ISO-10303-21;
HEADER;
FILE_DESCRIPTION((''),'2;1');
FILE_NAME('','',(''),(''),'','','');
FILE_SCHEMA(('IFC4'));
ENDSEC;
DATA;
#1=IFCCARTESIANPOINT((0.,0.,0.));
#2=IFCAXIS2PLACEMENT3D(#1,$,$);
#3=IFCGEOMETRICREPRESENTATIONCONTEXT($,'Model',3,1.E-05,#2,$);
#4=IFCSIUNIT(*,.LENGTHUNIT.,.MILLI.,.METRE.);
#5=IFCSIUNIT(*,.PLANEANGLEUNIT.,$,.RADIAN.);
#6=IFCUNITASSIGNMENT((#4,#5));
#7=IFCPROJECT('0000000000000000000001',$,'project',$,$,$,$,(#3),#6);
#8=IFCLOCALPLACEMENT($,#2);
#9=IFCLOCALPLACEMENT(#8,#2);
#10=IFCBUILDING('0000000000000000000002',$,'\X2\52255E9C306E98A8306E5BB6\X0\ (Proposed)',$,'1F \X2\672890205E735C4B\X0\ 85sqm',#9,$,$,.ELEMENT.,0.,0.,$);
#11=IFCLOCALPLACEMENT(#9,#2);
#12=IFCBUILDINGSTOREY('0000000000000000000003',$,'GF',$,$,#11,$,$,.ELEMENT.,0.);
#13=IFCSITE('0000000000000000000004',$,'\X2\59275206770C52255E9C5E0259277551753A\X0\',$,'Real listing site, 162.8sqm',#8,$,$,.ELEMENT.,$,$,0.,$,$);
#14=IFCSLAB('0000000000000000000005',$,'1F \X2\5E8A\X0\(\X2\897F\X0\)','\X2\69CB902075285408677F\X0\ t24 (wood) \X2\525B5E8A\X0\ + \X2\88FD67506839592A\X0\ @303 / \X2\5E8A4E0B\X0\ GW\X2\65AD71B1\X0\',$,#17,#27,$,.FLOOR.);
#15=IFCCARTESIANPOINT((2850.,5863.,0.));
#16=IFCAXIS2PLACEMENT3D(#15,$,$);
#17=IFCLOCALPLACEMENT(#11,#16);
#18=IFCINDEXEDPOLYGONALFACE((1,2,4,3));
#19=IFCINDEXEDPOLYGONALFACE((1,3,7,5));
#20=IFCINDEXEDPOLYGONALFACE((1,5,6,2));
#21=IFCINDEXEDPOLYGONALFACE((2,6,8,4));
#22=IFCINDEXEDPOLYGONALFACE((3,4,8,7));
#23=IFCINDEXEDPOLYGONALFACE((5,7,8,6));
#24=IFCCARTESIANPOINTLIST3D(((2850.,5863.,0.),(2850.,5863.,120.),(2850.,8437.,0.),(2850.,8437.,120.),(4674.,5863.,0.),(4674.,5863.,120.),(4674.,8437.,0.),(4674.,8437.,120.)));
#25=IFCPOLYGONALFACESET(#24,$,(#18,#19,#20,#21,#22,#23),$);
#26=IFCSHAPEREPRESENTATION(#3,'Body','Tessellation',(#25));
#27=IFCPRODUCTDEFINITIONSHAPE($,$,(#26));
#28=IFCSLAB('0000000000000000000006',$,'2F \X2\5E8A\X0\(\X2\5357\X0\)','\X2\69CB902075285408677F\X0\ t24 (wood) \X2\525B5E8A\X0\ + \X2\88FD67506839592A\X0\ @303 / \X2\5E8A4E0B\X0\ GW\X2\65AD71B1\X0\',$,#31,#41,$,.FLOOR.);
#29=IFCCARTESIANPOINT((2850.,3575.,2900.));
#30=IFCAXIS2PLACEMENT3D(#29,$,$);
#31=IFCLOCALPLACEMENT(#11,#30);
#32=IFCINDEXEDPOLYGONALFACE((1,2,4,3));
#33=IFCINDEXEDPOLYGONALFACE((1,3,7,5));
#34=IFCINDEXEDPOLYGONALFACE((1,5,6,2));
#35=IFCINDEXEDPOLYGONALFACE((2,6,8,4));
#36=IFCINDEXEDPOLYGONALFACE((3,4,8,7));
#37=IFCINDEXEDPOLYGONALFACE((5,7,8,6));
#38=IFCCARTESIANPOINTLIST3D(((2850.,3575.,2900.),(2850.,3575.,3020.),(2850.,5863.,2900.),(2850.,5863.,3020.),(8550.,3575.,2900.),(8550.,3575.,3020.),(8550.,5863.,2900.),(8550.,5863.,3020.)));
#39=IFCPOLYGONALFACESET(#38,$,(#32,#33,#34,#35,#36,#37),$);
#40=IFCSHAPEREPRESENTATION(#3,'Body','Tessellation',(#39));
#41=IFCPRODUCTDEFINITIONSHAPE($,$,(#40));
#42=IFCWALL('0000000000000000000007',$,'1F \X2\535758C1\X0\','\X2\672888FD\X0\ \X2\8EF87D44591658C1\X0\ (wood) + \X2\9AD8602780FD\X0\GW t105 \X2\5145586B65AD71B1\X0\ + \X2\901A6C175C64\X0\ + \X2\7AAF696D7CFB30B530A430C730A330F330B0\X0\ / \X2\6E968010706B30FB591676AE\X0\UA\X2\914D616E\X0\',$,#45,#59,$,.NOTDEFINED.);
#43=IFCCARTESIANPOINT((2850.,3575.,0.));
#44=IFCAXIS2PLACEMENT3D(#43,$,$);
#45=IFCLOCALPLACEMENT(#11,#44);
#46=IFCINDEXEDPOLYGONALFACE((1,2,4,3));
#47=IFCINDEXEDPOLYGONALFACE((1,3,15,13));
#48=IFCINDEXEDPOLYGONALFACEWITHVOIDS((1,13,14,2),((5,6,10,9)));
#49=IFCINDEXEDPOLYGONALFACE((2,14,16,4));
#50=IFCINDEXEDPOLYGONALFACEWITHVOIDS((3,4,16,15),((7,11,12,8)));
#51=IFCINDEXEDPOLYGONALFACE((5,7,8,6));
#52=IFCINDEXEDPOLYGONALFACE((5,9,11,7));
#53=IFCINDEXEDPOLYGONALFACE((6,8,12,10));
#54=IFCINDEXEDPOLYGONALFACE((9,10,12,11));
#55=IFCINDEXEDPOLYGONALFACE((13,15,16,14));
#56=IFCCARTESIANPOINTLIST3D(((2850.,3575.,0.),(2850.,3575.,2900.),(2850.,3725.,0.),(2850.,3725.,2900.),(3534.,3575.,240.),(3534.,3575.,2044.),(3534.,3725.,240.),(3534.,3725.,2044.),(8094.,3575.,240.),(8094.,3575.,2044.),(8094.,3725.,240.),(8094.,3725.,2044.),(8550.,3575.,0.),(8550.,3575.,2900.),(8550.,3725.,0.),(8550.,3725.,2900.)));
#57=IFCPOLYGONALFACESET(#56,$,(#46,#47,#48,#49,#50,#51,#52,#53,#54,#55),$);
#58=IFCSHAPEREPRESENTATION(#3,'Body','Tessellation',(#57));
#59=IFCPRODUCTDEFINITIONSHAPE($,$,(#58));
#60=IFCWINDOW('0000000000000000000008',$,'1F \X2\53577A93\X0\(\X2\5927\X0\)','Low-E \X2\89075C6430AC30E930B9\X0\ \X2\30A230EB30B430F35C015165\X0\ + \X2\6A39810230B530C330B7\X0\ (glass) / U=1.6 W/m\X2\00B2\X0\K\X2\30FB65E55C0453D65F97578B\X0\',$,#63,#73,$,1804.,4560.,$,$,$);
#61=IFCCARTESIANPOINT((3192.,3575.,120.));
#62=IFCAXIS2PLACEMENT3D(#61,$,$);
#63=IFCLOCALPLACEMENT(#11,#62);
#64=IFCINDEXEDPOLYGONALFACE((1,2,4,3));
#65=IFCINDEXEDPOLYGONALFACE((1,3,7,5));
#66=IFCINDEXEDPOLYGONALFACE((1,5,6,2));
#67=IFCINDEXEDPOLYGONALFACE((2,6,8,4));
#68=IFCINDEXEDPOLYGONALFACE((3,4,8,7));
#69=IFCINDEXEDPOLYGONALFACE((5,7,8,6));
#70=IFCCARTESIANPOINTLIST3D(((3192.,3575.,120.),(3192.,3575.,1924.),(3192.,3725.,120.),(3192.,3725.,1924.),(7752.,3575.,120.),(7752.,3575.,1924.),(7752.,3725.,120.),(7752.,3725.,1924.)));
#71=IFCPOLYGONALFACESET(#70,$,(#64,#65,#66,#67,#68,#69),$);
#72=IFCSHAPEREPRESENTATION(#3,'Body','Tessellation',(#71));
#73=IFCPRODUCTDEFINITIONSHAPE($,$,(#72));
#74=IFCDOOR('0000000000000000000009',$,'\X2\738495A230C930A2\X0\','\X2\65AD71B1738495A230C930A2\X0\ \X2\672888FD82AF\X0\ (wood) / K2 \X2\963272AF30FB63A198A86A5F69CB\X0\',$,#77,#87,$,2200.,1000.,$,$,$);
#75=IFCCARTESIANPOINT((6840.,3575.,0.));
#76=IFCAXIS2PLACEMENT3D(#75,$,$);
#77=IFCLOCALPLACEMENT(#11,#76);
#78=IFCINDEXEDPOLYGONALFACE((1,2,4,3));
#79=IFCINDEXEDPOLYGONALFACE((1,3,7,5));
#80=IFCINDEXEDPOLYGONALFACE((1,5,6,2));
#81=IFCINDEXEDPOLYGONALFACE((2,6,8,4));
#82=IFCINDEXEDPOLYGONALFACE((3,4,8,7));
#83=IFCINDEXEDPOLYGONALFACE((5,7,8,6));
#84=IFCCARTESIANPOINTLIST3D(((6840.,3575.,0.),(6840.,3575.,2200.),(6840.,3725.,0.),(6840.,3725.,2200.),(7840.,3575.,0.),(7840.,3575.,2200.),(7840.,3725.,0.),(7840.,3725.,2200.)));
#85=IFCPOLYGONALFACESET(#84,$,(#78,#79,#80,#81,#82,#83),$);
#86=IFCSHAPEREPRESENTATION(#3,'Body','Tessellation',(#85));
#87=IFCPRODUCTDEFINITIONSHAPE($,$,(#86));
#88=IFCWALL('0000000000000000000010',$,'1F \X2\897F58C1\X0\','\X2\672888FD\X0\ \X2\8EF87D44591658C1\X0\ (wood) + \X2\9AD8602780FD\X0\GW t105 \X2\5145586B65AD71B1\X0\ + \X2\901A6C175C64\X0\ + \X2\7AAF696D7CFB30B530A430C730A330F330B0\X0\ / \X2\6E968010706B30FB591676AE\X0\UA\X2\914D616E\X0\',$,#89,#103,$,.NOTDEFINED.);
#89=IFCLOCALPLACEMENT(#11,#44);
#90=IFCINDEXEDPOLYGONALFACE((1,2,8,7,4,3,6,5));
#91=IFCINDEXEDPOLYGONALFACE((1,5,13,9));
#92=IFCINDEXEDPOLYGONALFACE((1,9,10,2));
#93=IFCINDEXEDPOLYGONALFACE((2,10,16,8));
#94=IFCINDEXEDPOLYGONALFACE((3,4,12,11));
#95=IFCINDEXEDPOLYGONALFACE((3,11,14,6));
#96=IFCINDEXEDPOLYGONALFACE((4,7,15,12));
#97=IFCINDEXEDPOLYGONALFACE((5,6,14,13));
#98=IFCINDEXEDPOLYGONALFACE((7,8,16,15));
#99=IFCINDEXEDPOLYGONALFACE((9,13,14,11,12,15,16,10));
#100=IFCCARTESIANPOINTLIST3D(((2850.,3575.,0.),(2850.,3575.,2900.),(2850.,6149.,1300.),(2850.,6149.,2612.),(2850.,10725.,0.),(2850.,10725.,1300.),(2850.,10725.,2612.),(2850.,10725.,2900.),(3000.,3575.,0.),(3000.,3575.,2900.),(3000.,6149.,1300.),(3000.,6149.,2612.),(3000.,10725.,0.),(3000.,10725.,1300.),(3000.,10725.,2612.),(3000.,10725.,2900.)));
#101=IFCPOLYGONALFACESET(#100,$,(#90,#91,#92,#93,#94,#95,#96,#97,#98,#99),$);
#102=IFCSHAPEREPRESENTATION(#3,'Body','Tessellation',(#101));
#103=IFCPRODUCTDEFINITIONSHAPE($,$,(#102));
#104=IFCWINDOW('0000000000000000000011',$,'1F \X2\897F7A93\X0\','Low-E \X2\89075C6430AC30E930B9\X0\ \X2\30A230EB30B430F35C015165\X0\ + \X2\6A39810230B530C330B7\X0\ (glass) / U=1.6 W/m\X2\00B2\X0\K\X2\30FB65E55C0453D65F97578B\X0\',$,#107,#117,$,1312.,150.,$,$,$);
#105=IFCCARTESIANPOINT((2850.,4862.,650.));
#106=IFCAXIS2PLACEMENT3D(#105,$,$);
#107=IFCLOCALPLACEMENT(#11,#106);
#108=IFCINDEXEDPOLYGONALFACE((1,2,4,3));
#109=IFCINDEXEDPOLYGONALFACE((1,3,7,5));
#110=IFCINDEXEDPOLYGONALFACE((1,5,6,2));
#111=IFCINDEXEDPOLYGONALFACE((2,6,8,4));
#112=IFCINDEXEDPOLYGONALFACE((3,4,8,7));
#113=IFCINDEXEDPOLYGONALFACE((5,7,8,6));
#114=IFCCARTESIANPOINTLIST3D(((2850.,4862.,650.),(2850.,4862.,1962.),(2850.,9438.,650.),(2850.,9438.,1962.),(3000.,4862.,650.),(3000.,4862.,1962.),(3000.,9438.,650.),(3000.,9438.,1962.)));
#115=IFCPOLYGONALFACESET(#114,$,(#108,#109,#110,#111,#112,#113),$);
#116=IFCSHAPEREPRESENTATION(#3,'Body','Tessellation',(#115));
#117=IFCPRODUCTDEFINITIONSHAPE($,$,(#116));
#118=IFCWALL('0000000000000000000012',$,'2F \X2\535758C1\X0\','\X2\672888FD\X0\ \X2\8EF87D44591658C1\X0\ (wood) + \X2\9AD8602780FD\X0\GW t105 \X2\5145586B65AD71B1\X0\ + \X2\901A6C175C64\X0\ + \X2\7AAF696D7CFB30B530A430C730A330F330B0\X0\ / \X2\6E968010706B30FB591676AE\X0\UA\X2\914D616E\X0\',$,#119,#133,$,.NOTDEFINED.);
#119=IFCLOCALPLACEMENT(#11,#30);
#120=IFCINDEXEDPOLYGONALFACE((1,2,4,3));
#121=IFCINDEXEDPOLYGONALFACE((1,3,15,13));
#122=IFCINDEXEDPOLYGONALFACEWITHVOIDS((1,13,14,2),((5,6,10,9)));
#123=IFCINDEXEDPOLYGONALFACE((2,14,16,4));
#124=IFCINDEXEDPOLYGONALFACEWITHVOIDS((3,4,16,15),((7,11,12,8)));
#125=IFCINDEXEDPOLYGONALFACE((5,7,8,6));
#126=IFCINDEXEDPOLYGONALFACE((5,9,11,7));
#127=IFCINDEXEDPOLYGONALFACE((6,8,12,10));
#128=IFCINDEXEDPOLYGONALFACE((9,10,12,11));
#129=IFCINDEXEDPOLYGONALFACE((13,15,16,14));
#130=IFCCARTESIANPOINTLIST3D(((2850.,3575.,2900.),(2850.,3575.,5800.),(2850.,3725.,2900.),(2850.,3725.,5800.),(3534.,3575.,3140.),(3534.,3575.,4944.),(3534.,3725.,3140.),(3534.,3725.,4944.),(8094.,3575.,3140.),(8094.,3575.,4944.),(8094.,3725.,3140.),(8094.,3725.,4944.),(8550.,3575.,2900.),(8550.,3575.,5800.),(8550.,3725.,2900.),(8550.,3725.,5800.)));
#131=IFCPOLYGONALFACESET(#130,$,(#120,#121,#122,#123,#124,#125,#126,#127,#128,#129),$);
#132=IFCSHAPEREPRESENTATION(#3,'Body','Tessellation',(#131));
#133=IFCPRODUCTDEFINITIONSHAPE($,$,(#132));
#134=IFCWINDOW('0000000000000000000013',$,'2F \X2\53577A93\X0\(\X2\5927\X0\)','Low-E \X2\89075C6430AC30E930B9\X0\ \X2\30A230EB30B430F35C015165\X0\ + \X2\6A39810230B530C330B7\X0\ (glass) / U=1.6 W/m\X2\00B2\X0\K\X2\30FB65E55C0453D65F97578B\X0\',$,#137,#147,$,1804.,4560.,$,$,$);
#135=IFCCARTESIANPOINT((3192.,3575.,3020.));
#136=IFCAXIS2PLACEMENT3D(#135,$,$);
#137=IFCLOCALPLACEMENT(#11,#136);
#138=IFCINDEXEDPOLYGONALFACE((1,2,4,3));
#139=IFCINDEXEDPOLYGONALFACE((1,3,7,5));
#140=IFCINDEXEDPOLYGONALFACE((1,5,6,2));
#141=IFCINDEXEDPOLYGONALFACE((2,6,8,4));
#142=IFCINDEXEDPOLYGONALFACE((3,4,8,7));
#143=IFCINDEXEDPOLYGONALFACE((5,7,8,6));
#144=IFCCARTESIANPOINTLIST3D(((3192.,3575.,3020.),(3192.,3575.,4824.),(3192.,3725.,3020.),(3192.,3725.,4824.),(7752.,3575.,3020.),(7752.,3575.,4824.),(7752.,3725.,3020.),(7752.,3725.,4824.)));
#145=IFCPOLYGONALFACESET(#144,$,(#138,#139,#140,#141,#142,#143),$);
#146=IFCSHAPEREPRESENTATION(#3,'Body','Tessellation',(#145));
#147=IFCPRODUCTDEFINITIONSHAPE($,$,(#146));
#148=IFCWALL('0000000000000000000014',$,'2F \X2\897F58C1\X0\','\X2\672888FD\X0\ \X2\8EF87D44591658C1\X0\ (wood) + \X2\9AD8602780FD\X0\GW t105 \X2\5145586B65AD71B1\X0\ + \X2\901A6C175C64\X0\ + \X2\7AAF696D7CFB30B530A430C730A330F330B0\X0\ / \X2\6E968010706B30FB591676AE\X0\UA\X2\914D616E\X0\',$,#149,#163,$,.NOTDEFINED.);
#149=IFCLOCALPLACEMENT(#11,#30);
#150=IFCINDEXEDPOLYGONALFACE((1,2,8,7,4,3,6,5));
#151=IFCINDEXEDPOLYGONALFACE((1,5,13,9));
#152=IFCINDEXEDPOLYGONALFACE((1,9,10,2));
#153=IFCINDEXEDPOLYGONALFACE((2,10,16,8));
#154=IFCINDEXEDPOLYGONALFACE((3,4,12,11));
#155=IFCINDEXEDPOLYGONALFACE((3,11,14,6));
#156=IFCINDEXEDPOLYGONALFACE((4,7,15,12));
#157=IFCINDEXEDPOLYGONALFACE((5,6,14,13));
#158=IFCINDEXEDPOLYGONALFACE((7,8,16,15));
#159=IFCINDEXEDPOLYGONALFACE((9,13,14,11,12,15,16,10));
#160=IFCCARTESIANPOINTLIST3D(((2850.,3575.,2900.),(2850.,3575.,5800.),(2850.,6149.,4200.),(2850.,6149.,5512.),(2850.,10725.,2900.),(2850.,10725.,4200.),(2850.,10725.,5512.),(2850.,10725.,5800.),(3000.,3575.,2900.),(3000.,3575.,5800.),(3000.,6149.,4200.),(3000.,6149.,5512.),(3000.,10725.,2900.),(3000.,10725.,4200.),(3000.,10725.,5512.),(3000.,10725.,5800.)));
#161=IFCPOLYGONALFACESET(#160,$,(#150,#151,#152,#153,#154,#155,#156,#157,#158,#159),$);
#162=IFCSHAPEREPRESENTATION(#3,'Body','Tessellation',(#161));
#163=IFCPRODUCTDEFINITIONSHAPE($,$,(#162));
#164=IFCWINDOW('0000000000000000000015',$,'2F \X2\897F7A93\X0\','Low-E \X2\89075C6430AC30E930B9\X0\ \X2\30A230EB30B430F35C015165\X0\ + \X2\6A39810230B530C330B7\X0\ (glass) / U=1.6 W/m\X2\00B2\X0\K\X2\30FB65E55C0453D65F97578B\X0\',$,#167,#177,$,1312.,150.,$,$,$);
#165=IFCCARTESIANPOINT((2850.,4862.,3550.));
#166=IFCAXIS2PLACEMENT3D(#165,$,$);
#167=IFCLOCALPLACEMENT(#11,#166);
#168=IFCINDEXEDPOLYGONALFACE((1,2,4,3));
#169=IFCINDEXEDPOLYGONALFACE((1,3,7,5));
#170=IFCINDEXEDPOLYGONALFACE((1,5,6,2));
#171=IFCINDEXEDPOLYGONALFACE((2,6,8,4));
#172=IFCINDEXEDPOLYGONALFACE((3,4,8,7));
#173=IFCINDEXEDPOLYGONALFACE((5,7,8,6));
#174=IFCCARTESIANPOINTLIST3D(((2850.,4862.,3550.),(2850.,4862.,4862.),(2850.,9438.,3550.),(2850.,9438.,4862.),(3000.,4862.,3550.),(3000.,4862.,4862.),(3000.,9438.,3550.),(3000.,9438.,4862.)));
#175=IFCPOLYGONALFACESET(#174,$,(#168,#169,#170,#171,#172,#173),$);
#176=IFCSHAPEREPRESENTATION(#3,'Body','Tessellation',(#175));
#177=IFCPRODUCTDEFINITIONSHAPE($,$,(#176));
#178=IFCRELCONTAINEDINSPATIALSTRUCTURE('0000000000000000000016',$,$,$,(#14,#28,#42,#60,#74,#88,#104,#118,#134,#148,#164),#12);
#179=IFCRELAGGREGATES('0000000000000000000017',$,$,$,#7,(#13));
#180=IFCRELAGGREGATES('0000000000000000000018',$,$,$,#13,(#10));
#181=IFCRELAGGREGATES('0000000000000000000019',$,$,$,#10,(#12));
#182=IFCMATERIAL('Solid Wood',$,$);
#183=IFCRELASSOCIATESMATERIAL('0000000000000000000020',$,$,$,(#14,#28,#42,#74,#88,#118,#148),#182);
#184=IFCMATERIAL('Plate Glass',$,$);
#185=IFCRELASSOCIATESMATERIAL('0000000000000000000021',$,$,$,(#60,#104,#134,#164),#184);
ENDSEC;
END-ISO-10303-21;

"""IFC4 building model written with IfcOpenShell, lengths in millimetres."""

from ifc_helpers import new_model, si_unit, frame, frame_2d, origin, place, context, project, spatial, rectangle, extrude, material, element, fill, save


model = new_model("IFC4")

# Units and contexts
model_context = context("Model", 3, precision=1e-05, world=origin())
ifc_project = project(units=[si_unit("LENGTHUNIT", "METRE", prefix="MILLI"), si_unit("PLANEANGLEUNIT", "RADIAN")], contexts=[model_context])

# Site, building, storey
site_placement = place(None, origin())
site = spatial("IfcSite", under=ifc_project, at=site_placement, Name="大分県別府市大畑町", ObjectType="Real listing site, 162.8sqm", CompositionType="ELEMENT", RefElevation=0.0)
building_placement = place(site_placement, origin())
building = spatial("IfcBuilding", under=site, at=building_placement, Name="別府の風の家 (Proposed)", ObjectType="1F 木造平屋 85sqm", CompositionType="ELEMENT", ElevationOfRefHeight=0.0, ElevationOfTerrain=0.0)
storey_placement = place(building_placement, origin())
storey = spatial("IfcBuildingStorey", under=building, at=storey_placement, Name="GF", CompositionType="ELEMENT", Elevation=0.0)

# Slabs
ifc_material_1 = material(Name="Solid Wood")
slab_1_placement = place(storey_placement, frame((2850.0, 5863.0, 0.0)))
element("IfcSlab", 1, at=slab_1_placement, inside=storey, material=ifc_material_1, Name="1F 床(西)", Description="構造用合板 t24 (wood) 剛床 + 製材根太 @303 / 床下 GW断熱", PredefinedType="FLOOR", context=model_context, shape_type="SweptSolid", body=[
    extrude(rectangle(XDim=1824.0, YDim=2574.0, at=frame_2d((912.0, 1287.0))), frame((2850.0, 5863.0, 0.0)), (0.0, 0.0, 1.0), 120.0),
])
slab_2_placement = place(storey_placement, frame((2850.0, 3575.0, 2900.0)))
element("IfcSlab", 2, at=slab_2_placement, inside=storey, material=ifc_material_1, Name="2F 床(南)", Description="構造用合板 t24 (wood) 剛床 + 製材根太 @303 / 床下 GW断熱", PredefinedType="FLOOR", context=model_context, shape_type="SweptSolid", body=[
    extrude(rectangle(XDim=5700.0, YDim=2288.0, at=frame_2d((2850.0, 1144.0))), frame((2850.0, 3575.0, 2900.0)), (0.0, 0.0, 1.0), 120.0),
])

# Wall, openings, window, door
wall_1_placement = place(storey_placement, frame((2850.0, 3575.0, 0.0)))
wall_1 = element("IfcWall", 3, at=wall_1_placement, inside=storey, material=ifc_material_1, Name="1F 南壁", Description="木製 軸組外壁 (wood) + 高性能GW t105 充填断熱 + 通気層 + 窯業系サイディング / 準耐火・外皮UA配慮", PredefinedType="NOTDEFINED", context=model_context, shape_type="SweptSolid", body=[
    extrude(rectangle(XDim=5700.0, YDim=150.0, at=frame_2d((2850.0, 75.0))), frame((2850.0, 3575.0, 0.0)), (0.0, 0.0, 1.0), 2900.0),
])
opening_1_placement = place(storey_placement, frame((3192.0, 3575.0, 120.0)))
opening_1 = element("IfcOpeningElement", 4, at=opening_1_placement, cuts=wall_1, PredefinedType="NOTDEFINED", context=model_context, shape_type="SweptSolid", body=[
    extrude(rectangle(XDim=4560.0, YDim=150.0, at=frame_2d((2280.0, 75.0))), frame((3192.0, 3575.0, 120.0)), (0.0, 0.0, 1.0), 1804.0),
])
opening_2_placement = place(storey_placement, frame((6840.0, 3575.0, 0.0)))
opening_2 = element("IfcOpeningElement", 5, at=opening_2_placement, cuts=wall_1, PredefinedType="NOTDEFINED", context=model_context, shape_type="SweptSolid", body=[
    extrude(rectangle(XDim=1000.0, YDim=150.0, at=frame_2d((500.0, 75.0))), frame((6840.0, 3575.0, 0.0)), (0.0, 0.0, 1.0), 2200.0),
])
ifc_material_2 = material(Name="Plate Glass")
window_1_placement = place(storey_placement, frame((3192.0, 3575.0, 120.0)))
window_1 = element("IfcWindow", 6, at=window_1_placement, inside=storey, material=ifc_material_2, Name="1F 南窓(大)", Description="Low-E 複層ガラス アルゴン封入 + 樹脂サッシ (glass) / U=1.6 W/m²K・日射取得型", OverallHeight=1804.0, OverallWidth=4560.0, context=model_context, shape_type="SweptSolid", body=[
    extrude(rectangle(XDim=4560.0, YDim=150.0, at=frame_2d((2280.0, 75.0))), frame((3192.0, 3575.0, 120.0)), (0.0, 0.0, 1.0), 1804.0),
])
fill(opening_1, window_1)
door_placement = place(storey_placement, frame((6840.0, 3575.0, 0.0)))
door = element("IfcDoor", 7, at=door_placement, inside=storey, material=ifc_material_1, Name="玄関ドア", Description="断熱玄関ドア 木製芯 (wood) / K2 防犯・採風機構", OverallHeight=2200.0, OverallWidth=1000.0, context=model_context, shape_type="SweptSolid", body=[
    extrude(rectangle(XDim=1000.0, YDim=150.0, at=frame_2d((500.0, 75.0))), frame((6840.0, 3575.0, 0.0)), (0.0, 0.0, 1.0), 2200.0),
])
fill(opening_2, door)

# Walls, openings, windows
wall_2_placement = place(storey_placement, frame((2850.0, 3575.0, 0.0)))
wall_2 = element("IfcWall", 8, at=wall_2_placement, inside=storey, material=ifc_material_1, Name="1F 西壁", Description="木製 軸組外壁 (wood) + 高性能GW t105 充填断熱 + 通気層 + 窯業系サイディング / 準耐火・外皮UA配慮", PredefinedType="NOTDEFINED", context=model_context, shape_type="SweptSolid", body=[
    extrude(rectangle(XDim=150.0, YDim=7150.0, at=frame_2d((75.0, 3575.0))), frame((2850.0, 3575.0, 0.0)), (0.0, 0.0, 1.0), 2900.0),
])
opening_3_placement = place(storey_placement, frame((2850.0, 4862.0, 650.0)))
opening_3 = element("IfcOpeningElement", 9, at=opening_3_placement, cuts=wall_2, PredefinedType="NOTDEFINED", context=model_context, shape_type="SweptSolid", body=[
    extrude(rectangle(XDim=150.0, YDim=4576.0, at=frame_2d((75.0, 2288.0))), frame((2850.0, 4862.0, 650.0)), (0.0, 0.0, 1.0), 1312.0),
])
window_2_placement = place(storey_placement, frame((2850.0, 4862.0, 650.0)))
window_2 = element("IfcWindow", 10, at=window_2_placement, inside=storey, material=ifc_material_2, Name="1F 西窓", Description="Low-E 複層ガラス アルゴン封入 + 樹脂サッシ (glass) / U=1.6 W/m²K・日射取得型", OverallHeight=1312.0, OverallWidth=150.0, context=model_context, shape_type="SweptSolid", body=[
    extrude(rectangle(XDim=150.0, YDim=4576.0, at=frame_2d((75.0, 2288.0))), frame((2850.0, 4862.0, 650.0)), (0.0, 0.0, 1.0), 1312.0),
])
fill(opening_3, window_2)
wall_3_placement = place(storey_placement, frame((2850.0, 3575.0, 2900.0)))
wall_3 = element("IfcWall", 11, at=wall_3_placement, inside=storey, material=ifc_material_1, Name="2F 南壁", Description="木製 軸組外壁 (wood) + 高性能GW t105 充填断熱 + 通気層 + 窯業系サイディング / 準耐火・外皮UA配慮", PredefinedType="NOTDEFINED", context=model_context, shape_type="SweptSolid", body=[
    extrude(rectangle(XDim=5700.0, YDim=150.0, at=frame_2d((2850.0, 75.0))), frame((2850.0, 3575.0, 2900.0)), (0.0, 0.0, 1.0), 2900.0),
])
opening_4_placement = place(storey_placement, frame((3192.0, 3575.0, 3020.0)))
opening_4 = element("IfcOpeningElement", 12, at=opening_4_placement, cuts=wall_3, PredefinedType="NOTDEFINED", context=model_context, shape_type="SweptSolid", body=[
    extrude(rectangle(XDim=4560.0, YDim=150.0, at=frame_2d((2280.0, 75.0))), frame((3192.0, 3575.0, 3020.0)), (0.0, 0.0, 1.0), 1804.0),
])
window_3_placement = place(storey_placement, frame((3192.0, 3575.0, 3020.0)))
window_3 = element("IfcWindow", 13, at=window_3_placement, inside=storey, material=ifc_material_2, Name="2F 南窓(大)", Description="Low-E 複層ガラス アルゴン封入 + 樹脂サッシ (glass) / U=1.6 W/m²K・日射取得型", OverallHeight=1804.0, OverallWidth=4560.0, context=model_context, shape_type="SweptSolid", body=[
    extrude(rectangle(XDim=4560.0, YDim=150.0, at=frame_2d((2280.0, 75.0))), frame((3192.0, 3575.0, 3020.0)), (0.0, 0.0, 1.0), 1804.0),
])
fill(opening_4, window_3)
wall_4_placement = place(storey_placement, frame((2850.0, 3575.0, 2900.0)))
wall_4 = element("IfcWall", 14, at=wall_4_placement, inside=storey, material=ifc_material_1, Name="2F 西壁", Description="木製 軸組外壁 (wood) + 高性能GW t105 充填断熱 + 通気層 + 窯業系サイディング / 準耐火・外皮UA配慮", PredefinedType="NOTDEFINED", context=model_context, shape_type="SweptSolid", body=[
    extrude(rectangle(XDim=150.0, YDim=7150.0, at=frame_2d((75.0, 3575.0))), frame((2850.0, 3575.0, 2900.0)), (0.0, 0.0, 1.0), 2900.0),
])
opening_5_placement = place(storey_placement, frame((2850.0, 4862.0, 3550.0)))
opening_5 = element("IfcOpeningElement", 15, at=opening_5_placement, cuts=wall_4, PredefinedType="NOTDEFINED", context=model_context, shape_type="SweptSolid", body=[
    extrude(rectangle(XDim=150.0, YDim=4576.0, at=frame_2d((75.0, 2288.0))), frame((2850.0, 4862.0, 3550.0)), (0.0, 0.0, 1.0), 1312.0),
])
window_4_placement = place(storey_placement, frame((2850.0, 4862.0, 3550.0)))
window_4 = element("IfcWindow", 16, at=window_4_placement, inside=storey, material=ifc_material_2, Name="2F 西窓", Description="Low-E 複層ガラス アルゴン封入 + 樹脂サッシ (glass) / U=1.6 W/m²K・日射取得型", OverallHeight=1312.0, OverallWidth=150.0, context=model_context, shape_type="SweptSolid", body=[
    extrude(rectangle(XDim=150.0, YDim=4576.0, at=frame_2d((75.0, 2288.0))), frame((2850.0, 4862.0, 3550.0)), (0.0, 0.0, 1.0), 1312.0),
])
fill(opening_5, window_4)

save(model, "model.ifc")
